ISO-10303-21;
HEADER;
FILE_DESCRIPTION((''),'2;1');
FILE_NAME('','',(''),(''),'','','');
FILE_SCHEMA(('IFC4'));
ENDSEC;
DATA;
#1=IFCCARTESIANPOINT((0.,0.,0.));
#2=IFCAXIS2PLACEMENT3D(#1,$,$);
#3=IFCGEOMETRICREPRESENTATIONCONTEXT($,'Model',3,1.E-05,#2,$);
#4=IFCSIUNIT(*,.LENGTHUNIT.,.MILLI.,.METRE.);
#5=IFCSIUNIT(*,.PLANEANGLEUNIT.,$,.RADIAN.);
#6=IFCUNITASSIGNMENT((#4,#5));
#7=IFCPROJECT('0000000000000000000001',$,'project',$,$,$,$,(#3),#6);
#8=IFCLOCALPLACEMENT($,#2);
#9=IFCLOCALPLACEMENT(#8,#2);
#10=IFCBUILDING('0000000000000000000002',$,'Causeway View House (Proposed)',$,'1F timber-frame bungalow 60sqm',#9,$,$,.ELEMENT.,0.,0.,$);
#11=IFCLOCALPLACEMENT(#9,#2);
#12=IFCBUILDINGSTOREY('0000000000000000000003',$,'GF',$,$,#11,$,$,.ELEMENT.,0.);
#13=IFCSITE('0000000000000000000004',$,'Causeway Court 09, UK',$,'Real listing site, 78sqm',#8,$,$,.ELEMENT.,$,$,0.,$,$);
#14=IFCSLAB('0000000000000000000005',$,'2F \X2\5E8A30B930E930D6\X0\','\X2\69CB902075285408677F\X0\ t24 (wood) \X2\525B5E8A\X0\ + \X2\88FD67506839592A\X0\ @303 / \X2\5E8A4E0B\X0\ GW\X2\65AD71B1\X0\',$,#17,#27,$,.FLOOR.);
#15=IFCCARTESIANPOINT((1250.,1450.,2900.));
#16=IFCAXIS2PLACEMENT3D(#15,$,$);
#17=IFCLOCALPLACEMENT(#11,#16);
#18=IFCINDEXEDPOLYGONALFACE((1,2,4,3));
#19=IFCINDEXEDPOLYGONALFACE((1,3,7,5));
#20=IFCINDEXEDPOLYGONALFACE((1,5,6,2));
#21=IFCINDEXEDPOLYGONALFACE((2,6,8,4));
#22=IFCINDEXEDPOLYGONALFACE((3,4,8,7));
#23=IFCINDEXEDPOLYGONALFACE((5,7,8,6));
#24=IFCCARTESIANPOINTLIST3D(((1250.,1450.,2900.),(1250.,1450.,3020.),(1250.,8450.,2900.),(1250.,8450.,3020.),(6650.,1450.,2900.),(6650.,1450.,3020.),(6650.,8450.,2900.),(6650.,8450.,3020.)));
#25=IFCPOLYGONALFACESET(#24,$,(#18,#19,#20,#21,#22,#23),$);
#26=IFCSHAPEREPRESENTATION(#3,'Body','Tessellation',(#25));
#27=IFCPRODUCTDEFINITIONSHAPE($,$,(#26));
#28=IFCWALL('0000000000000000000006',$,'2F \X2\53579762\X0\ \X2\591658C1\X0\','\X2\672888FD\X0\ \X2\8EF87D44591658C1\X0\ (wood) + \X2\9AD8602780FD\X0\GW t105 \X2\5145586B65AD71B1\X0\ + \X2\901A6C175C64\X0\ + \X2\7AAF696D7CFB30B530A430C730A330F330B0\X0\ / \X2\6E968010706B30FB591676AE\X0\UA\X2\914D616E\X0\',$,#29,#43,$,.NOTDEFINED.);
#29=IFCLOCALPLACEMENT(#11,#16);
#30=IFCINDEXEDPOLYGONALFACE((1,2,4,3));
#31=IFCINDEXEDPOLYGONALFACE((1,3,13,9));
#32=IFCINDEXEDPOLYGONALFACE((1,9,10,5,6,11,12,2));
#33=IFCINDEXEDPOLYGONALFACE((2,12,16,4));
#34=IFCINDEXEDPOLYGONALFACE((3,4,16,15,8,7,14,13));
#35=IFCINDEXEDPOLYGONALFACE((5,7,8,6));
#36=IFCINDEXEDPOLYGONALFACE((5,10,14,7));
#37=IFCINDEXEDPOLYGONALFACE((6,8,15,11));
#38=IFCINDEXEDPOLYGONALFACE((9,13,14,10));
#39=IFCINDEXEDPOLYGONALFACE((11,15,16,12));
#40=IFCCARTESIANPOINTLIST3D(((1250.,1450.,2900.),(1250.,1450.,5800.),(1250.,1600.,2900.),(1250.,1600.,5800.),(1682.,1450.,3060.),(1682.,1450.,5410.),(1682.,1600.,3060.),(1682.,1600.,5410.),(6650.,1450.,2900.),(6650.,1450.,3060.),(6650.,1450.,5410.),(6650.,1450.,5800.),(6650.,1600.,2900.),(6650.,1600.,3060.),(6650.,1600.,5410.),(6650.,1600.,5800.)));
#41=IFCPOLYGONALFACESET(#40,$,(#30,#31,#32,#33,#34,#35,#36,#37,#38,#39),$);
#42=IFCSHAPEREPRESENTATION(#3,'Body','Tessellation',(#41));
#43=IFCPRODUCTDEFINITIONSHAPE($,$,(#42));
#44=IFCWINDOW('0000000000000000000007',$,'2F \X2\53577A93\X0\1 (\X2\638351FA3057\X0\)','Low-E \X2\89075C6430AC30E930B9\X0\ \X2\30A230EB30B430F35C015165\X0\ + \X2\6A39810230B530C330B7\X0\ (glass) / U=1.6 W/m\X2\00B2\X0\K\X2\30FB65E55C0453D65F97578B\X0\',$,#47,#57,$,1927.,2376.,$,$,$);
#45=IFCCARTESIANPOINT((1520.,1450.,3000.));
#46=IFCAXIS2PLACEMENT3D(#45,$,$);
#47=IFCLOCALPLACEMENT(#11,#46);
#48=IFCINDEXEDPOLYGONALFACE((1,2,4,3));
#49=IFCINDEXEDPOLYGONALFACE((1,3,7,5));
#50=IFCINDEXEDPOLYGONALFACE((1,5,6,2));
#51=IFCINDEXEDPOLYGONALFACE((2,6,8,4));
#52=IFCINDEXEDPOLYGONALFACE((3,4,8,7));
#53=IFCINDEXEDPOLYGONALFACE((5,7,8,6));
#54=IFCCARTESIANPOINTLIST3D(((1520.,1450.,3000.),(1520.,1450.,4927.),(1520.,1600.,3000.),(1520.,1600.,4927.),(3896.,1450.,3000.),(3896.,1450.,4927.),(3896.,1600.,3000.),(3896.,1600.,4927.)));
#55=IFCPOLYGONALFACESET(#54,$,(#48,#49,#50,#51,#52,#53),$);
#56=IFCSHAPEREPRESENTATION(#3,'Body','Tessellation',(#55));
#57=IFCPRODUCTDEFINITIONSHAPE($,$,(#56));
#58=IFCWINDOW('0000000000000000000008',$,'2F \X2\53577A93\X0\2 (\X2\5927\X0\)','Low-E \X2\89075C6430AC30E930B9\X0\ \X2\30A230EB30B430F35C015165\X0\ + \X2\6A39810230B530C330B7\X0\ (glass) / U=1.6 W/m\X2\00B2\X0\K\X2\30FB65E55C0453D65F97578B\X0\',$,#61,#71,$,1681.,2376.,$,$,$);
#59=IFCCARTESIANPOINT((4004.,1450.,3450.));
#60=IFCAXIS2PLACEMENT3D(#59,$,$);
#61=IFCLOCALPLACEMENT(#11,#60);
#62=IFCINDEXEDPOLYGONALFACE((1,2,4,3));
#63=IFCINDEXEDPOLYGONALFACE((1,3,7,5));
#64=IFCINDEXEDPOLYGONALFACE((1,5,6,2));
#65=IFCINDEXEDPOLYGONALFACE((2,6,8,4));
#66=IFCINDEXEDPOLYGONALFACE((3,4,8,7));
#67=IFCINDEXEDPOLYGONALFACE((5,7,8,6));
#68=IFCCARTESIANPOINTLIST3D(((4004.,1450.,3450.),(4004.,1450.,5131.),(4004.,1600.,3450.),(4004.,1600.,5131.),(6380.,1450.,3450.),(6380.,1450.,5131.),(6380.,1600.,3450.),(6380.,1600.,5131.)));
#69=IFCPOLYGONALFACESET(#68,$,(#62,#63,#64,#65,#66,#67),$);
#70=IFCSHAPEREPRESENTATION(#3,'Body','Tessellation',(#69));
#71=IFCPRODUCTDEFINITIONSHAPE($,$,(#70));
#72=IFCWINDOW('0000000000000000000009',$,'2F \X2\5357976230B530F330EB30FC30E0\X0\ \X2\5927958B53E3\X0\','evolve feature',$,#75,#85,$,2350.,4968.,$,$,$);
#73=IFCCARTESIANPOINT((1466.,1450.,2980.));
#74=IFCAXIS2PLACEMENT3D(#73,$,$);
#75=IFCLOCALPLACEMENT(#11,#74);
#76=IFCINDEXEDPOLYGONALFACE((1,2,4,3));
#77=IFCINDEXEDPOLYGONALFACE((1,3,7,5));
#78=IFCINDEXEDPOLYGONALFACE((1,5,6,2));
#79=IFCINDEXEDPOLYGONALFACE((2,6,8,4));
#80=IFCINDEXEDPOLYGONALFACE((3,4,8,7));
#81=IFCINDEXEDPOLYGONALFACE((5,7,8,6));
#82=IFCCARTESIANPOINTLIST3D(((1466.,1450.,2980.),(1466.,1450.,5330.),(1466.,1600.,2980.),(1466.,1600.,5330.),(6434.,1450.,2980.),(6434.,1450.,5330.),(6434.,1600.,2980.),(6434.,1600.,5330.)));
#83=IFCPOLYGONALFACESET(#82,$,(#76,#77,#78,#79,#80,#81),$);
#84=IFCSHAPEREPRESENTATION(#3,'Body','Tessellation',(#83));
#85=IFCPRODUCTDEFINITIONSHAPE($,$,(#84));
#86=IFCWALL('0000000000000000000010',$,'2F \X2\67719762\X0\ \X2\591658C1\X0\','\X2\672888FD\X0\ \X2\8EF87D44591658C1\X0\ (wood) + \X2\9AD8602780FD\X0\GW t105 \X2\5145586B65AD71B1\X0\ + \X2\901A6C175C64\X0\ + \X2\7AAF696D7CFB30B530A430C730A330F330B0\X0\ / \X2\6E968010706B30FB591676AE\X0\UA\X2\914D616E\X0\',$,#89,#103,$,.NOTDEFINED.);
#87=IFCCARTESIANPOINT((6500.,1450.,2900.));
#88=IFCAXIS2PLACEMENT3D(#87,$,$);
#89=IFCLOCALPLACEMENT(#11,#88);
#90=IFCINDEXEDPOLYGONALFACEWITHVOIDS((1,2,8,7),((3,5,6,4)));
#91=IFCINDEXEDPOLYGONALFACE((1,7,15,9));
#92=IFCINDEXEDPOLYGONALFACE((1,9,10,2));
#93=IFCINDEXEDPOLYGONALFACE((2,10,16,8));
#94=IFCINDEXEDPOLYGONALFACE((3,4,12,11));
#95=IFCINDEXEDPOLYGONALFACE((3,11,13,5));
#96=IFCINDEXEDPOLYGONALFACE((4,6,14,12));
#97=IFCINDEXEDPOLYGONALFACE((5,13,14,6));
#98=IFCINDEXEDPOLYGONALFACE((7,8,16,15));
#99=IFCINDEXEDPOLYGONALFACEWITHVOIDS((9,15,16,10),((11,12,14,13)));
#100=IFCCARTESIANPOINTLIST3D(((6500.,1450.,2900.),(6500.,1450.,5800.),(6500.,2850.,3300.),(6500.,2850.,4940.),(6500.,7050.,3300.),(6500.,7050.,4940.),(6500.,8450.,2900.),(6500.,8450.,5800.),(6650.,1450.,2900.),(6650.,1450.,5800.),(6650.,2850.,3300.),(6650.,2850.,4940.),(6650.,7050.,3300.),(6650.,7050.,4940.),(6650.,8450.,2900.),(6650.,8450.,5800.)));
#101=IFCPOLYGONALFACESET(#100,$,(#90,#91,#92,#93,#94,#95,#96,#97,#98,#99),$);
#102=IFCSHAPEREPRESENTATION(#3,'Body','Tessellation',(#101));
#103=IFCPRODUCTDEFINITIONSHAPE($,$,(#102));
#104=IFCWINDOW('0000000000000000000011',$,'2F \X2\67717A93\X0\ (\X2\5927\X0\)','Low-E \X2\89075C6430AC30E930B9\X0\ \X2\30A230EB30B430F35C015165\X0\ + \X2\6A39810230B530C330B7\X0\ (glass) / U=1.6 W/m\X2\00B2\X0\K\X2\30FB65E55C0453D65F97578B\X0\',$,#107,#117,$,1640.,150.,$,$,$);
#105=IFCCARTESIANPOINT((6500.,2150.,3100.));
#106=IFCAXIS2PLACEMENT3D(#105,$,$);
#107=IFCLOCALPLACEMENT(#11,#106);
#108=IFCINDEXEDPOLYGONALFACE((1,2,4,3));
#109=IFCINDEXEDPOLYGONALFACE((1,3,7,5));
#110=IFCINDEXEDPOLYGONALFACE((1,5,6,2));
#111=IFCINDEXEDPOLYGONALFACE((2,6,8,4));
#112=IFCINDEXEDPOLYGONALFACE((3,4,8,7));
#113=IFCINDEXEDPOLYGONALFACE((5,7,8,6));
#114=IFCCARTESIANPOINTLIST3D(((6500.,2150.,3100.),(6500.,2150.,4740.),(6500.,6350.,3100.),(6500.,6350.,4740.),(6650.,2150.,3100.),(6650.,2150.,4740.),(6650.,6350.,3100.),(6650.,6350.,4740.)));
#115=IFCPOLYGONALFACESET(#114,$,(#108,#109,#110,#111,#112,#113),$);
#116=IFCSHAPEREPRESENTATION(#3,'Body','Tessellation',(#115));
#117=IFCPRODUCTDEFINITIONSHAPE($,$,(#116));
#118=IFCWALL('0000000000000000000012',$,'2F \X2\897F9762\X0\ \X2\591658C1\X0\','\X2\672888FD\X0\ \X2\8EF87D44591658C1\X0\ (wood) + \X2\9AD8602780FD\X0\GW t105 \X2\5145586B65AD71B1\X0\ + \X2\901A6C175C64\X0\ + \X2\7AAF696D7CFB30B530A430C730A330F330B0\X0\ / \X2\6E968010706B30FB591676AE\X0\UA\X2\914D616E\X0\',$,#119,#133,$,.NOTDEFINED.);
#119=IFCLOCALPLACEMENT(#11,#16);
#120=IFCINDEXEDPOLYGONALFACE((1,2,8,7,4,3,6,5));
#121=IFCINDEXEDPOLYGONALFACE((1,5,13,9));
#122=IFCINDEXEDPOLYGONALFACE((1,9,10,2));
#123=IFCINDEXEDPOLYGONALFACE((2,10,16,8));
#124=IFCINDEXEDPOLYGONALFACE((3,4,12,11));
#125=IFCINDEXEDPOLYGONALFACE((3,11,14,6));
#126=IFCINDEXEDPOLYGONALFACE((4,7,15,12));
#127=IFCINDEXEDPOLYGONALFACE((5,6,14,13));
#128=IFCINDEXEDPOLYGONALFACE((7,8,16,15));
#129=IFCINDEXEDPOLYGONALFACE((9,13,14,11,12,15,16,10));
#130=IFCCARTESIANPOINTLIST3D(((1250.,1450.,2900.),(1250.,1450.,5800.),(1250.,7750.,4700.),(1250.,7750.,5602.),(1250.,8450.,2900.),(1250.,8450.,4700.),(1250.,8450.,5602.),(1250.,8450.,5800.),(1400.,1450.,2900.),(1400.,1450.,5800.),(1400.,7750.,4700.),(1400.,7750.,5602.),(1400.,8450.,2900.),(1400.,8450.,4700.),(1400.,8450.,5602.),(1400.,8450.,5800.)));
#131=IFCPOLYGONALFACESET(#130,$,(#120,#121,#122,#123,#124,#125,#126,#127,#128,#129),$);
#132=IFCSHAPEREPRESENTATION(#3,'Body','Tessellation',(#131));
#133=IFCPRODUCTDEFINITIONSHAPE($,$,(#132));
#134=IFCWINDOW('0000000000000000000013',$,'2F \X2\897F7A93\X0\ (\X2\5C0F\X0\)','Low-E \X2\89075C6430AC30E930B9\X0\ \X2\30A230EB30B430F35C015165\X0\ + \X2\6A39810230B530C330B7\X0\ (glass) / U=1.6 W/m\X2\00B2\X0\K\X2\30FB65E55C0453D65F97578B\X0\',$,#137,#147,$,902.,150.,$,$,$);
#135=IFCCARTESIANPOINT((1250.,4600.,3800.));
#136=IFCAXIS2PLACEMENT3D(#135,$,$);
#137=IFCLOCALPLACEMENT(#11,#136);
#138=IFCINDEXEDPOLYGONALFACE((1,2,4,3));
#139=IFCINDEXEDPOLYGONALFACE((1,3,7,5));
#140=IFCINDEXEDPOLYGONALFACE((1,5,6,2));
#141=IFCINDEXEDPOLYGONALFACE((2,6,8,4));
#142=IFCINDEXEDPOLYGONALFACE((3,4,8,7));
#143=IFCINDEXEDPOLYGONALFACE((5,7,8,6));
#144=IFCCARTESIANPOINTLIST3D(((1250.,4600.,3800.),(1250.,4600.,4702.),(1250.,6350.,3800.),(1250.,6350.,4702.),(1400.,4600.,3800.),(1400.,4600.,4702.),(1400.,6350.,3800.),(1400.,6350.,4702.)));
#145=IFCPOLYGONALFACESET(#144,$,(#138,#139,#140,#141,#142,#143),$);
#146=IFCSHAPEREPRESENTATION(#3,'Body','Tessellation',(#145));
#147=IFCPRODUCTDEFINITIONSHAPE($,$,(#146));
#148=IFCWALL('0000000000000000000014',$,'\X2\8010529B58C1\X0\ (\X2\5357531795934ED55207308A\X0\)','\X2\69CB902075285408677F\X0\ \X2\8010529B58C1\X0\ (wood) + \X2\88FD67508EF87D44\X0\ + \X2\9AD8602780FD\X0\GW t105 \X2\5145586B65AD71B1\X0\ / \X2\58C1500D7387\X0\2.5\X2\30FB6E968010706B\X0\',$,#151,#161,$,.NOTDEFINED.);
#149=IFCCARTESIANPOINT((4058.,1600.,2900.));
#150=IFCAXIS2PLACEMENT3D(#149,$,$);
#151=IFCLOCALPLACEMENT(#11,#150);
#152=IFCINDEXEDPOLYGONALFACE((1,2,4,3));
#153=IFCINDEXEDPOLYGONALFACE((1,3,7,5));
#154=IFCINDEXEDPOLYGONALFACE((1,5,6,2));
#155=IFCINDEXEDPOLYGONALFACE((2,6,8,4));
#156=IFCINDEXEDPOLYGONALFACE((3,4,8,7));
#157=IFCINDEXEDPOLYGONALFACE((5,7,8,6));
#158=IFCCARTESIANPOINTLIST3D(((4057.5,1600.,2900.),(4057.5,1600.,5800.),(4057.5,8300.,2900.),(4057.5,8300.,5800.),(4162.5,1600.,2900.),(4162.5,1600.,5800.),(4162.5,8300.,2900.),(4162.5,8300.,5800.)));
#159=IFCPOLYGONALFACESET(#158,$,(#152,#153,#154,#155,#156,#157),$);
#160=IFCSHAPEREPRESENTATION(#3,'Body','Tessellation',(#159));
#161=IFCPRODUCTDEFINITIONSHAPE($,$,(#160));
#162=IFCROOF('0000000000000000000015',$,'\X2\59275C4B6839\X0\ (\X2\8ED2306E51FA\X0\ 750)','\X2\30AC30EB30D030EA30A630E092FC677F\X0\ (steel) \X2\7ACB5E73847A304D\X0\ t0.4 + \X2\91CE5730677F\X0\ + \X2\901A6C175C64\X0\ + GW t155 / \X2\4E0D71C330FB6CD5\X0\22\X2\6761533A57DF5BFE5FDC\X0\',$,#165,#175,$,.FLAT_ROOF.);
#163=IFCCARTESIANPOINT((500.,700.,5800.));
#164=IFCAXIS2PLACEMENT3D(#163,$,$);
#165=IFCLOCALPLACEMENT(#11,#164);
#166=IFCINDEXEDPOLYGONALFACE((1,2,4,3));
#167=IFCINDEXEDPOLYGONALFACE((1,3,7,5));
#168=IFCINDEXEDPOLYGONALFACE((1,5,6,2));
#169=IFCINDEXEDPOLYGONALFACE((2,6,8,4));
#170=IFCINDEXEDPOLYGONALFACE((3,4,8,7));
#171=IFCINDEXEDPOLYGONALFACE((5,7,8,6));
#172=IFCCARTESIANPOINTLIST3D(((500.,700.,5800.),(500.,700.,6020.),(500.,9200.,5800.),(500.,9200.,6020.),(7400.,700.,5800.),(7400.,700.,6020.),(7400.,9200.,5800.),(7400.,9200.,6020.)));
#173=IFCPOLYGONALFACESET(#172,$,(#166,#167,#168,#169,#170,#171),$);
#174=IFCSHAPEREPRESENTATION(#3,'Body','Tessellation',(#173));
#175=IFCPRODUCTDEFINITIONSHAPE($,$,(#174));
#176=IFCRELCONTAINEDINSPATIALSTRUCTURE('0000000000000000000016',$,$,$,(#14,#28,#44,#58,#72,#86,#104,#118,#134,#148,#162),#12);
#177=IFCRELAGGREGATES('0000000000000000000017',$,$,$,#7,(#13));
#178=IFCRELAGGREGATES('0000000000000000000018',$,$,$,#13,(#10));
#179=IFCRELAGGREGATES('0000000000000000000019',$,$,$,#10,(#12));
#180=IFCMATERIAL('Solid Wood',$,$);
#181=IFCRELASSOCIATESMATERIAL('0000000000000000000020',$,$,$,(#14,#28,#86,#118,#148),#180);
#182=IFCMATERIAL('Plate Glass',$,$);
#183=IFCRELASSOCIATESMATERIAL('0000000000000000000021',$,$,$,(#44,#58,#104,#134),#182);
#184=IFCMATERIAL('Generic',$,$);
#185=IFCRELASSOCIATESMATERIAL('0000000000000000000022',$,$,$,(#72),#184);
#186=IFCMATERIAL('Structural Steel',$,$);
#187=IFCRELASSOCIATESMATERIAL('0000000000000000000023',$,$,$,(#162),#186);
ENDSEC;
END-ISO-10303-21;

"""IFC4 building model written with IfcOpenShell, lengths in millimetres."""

from ifc_helpers import new_model, si_unit, frame, frame_2d, origin, place, context, project, spatial, rectangle, extrude, material, element, fill, save


model = new_model("IFC4")

# Units and contexts
model_context = context("Model", 3, precision=1e-05, world=origin())
ifc_project = project(units=[si_unit("LENGTHUNIT", "METRE", prefix="MILLI"), si_unit("PLANEANGLEUNIT", "RADIAN")], contexts=[model_context])

# Site, building, storey
site_placement = place(None, origin())
site = spatial("IfcSite", under=ifc_project, at=site_placement, Name="Causeway Court 09, UK", ObjectType="Real listing site, 78sqm", CompositionType="ELEMENT", RefElevation=0.0)
building_placement = place(site_placement, origin())
building = spatial("IfcBuilding", under=site, at=building_placement, Name="Causeway View House (Proposed)", ObjectType="1F timber-frame bungalow 60sqm", CompositionType="ELEMENT", ElevationOfRefHeight=0.0, ElevationOfTerrain=0.0)
storey_placement = place(building_placement, origin())
storey = spatial("IfcBuildingStorey", under=building, at=storey_placement, Name="GF", CompositionType="ELEMENT", Elevation=0.0)

# Slab
ifc_material_1 = material(Name="Solid Wood")
slab_placement = place(storey_placement, frame((1250.0, 1450.0, 2900.0)))
element("IfcSlab", 1, at=slab_placement, inside=storey, material=ifc_material_1, Name="2F 床スラブ", Description="構造用合板 t24 (wood) 剛床 + 製材根太 @303 / 床下 GW断熱", PredefinedType="FLOOR", context=model_context, shape_type="SweptSolid", body=[
    extrude(rectangle(XDim=5400.0, YDim=7000.0, at=frame_2d((2700.0, 3500.0))), frame((1250.0, 1450.0, 2900.0)), (0.0, 0.0, 1.0), 120.0),
])

# Wall, openings, windows
wall_1_placement = place(storey_placement, frame((1250.0, 1450.0, 2900.0)))
wall_1 = element("IfcWall", 2, at=wall_1_placement, inside=storey, material=ifc_material_1, Name="2F 南面 外壁", Description="木製 軸組外壁 (wood) + 高性能GW t105 充填断熱 + 通気層 + 窯業系サイディング / 準耐火・外皮UA配慮", PredefinedType="NOTDEFINED", context=model_context, shape_type="SweptSolid", body=[
    extrude(rectangle(XDim=5400.0, YDim=150.0, at=frame_2d((2700.0, 75.0))), frame((1250.0, 1450.0, 2900.0)), (0.0, 0.0, 1.0), 2900.0),
])
opening_1_placement = place(storey_placement, frame((1520.0, 1450.0, 3000.0)))
opening_1 = element("IfcOpeningElement", 3, at=opening_1_placement, cuts=wall_1, PredefinedType="NOTDEFINED", context=model_context, shape_type="SweptSolid", body=[
    extrude(rectangle(XDim=2376.0, YDim=150.0, at=frame_2d((1188.0, 75.0))), frame((1520.0, 1450.0, 3000.0)), (0.0, 0.0, 1.0), 1927.0),
])
opening_2_placement = place(storey_placement, frame((4004.0, 1450.0, 3450.0)))
opening_2 = element("IfcOpeningElement", 4, at=opening_2_placement, cuts=wall_1, PredefinedType="NOTDEFINED", context=model_context, shape_type="SweptSolid", body=[
    extrude(rectangle(XDim=2376.0, YDim=150.0, at=frame_2d((1188.0, 75.0))), frame((4004.0, 1450.0, 3450.0)), (0.0, 0.0, 1.0), 1681.0),
])
opening_3_placement = place(storey_placement, frame((1466.0, 1450.0, 2980.0)))
opening_3 = element("IfcOpeningElement", 5, at=opening_3_placement, cuts=wall_1, PredefinedType="NOTDEFINED", context=model_context, shape_type="SweptSolid", body=[
    extrude(rectangle(XDim=4968.0, YDim=150.0, at=frame_2d((2484.0, 75.0))), frame((1466.0, 1450.0, 2980.0)), (0.0, 0.0, 1.0), 2350.0),
])
ifc_material_2 = material(Name="Plate Glass")
window_1_placement = place(storey_placement, frame((1520.0, 1450.0, 3000.0)))
window_1 = element("IfcWindow", 6, at=window_1_placement, inside=storey, material=ifc_material_2, Name="2F 南窓1 (掃出し)", Description="Low-E 複層ガラス アルゴン封入 + 樹脂サッシ (glass) / U=1.6 W/m²K・日射取得型", OverallHeight=1927.0, OverallWidth=2376.0, context=model_context, shape_type="SweptSolid", body=[
    extrude(rectangle(XDim=2376.0, YDim=150.0, at=frame_2d((1188.0, 75.0))), frame((1520.0, 1450.0, 3000.0)), (0.0, 0.0, 1.0), 1927.0),
])
fill(opening_1, window_1)
window_2_placement = place(storey_placement, frame((4004.0, 1450.0, 3450.0)))
window_2 = element("IfcWindow", 7, at=window_2_placement, inside=storey, material=ifc_material_2, Name="2F 南窓2 (大)", Description="Low-E 複層ガラス アルゴン封入 + 樹脂サッシ (glass) / U=1.6 W/m²K・日射取得型", OverallHeight=1681.0, OverallWidth=2376.0, context=model_context, shape_type="SweptSolid", body=[
    extrude(rectangle(XDim=2376.0, YDim=150.0, at=frame_2d((1188.0, 75.0))), frame((4004.0, 1450.0, 3450.0)), (0.0, 0.0, 1.0), 1681.0),
])
fill(opening_2, window_2)
ifc_material_3 = material(Name="Generic")
window_3_placement = place(storey_placement, frame((1466.0, 1450.0, 2980.0)))
window_3 = element("IfcWindow", 8, at=window_3_placement, inside=storey, material=ifc_material_3, Name="2F 南面サンルーム 大開口", Description="evolve feature", OverallHeight=2350.0, OverallWidth=4968.0, context=model_context, shape_type="SweptSolid", body=[
    extrude(rectangle(XDim=4968.0, YDim=150.0, at=frame_2d((2484.0, 75.0))), frame((1466.0, 1450.0, 2980.0)), (0.0, 0.0, 1.0), 2350.0),
])
fill(opening_3, window_3)

# Walls, openings, windows
wall_2_placement = place(storey_placement, frame((6500.0, 1450.0, 2900.0)))
wall_2 = element("IfcWall", 9, at=wall_2_placement, inside=storey, material=ifc_material_1, Name="2F 東面 外壁", Description="木製 軸組外壁 (wood) + 高性能GW t105 充填断熱 + 通気層 + 窯業系サイディング / 準耐火・外皮UA配慮", PredefinedType="NOTDEFINED", context=model_context, shape_type="SweptSolid", body=[
    extrude(rectangle(XDim=150.0, YDim=7000.0, at=frame_2d((75.0, 3500.0))), frame((6500.0, 1450.0, 2900.0)), (0.0, 0.0, 1.0), 2900.0),
])
opening_4_placement = place(storey_placement, frame((6500.0, 2150.0, 3100.0)))
opening_4 = element("IfcOpeningElement", 10, at=opening_4_placement, cuts=wall_2, PredefinedType="NOTDEFINED", context=model_context, shape_type="SweptSolid", body=[
    extrude(rectangle(XDim=150.0, YDim=4200.0, at=frame_2d((75.0, 2100.0))), frame((6500.0, 2150.0, 3100.0)), (0.0, 0.0, 1.0), 1640.0),
])
window_4_placement = place(storey_placement, frame((6500.0, 2150.0, 3100.0)))
window_4 = element("IfcWindow", 11, at=window_4_placement, inside=storey, material=ifc_material_2, Name="2F 東窓 (大)", Description="Low-E 複層ガラス アルゴン封入 + 樹脂サッシ (glass) / U=1.6 W/m²K・日射取得型", OverallHeight=1640.0, OverallWidth=150.0, context=model_context, shape_type="SweptSolid", body=[
    extrude(rectangle(XDim=150.0, YDim=4200.0, at=frame_2d((75.0, 2100.0))), frame((6500.0, 2150.0, 3100.0)), (0.0, 0.0, 1.0), 1640.0),
])
fill(opening_4, window_4)
wall_3_placement = place(storey_placement, frame((1250.0, 1450.0, 2900.0)))
wall_3 = element("IfcWall", 12, at=wall_3_placement, inside=storey, material=ifc_material_1, Name="2F 西面 外壁", Description="木製 軸組外壁 (wood) + 高性能GW t105 充填断熱 + 通気層 + 窯業系サイディング / 準耐火・外皮UA配慮", PredefinedType="NOTDEFINED", context=model_context, shape_type="SweptSolid", body=[
    extrude(rectangle(XDim=150.0, YDim=7000.0, at=frame_2d((75.0, 3500.0))), frame((1250.0, 1450.0, 2900.0)), (0.0, 0.0, 1.0), 2900.0),
])
opening_5_placement = place(storey_placement, frame((1250.0, 4600.0, 3800.0)))
opening_5 = element("IfcOpeningElement", 13, at=opening_5_placement, cuts=wall_3, PredefinedType="NOTDEFINED", context=model_context, shape_type="SweptSolid", body=[
    extrude(rectangle(XDim=150.0, YDim=1750.0, at=frame_2d((75.0, 875.0))), frame((1250.0, 4600.0, 3800.0)), (0.0, 0.0, 1.0), 902.0),
])
window_5_placement = place(storey_placement, frame((1250.0, 4600.0, 3800.0)))
window_5 = element("IfcWindow", 14, at=window_5_placement, inside=storey, material=ifc_material_2, Name="2F 西窓 (小)", Description="Low-E 複層ガラス アルゴン封入 + 樹脂サッシ (glass) / U=1.6 W/m²K・日射取得型", OverallHeight=902.0, OverallWidth=150.0, context=model_context, shape_type="SweptSolid", body=[
    extrude(rectangle(XDim=150.0, YDim=1750.0, at=frame_2d((75.0, 875.0))), frame((1250.0, 4600.0, 3800.0)), (0.0, 0.0, 1.0), 902.0),
])
fill(opening_5, window_5)

# Wall
wall_4_placement = place(storey_placement, frame((4058.0, 1600.0, 2900.0)))
element("IfcWall", 15, at=wall_4_placement, inside=storey, material=ifc_material_1, Name="耐力壁 (南北間仕切り)", Description="構造用合板 耐力壁 (wood) + 製材軸組 + 高性能GW t105 充填断熱 / 壁倍率2.5・準耐火", PredefinedType="NOTDEFINED", context=model_context, shape_type="SweptSolid", body=[
    extrude(rectangle(XDim=105.0, YDim=6700.0, at=frame_2d((52.0, 3350.0))), frame((4058.0, 1600.0, 2900.0)), (0.0, 0.0, 1.0), 2900.0),
])

# Roof
ifc_material_4 = material(Name="Structural Steel")
roof_placement = place(storey_placement, frame((500.0, 700.0, 5800.0)))
element("IfcRoof", 16, at=roof_placement, inside=storey, material=ifc_material_4, Name="大屋根 (軒の出 750)", Description="ガルバリウム鋼板 (steel) 立平葺き t0.4 + 野地板 + 通気層 + GW t155 / 不燃・法22条区域対応", PredefinedType="FLAT_ROOF", context=model_context, shape_type="SweptSolid", body=[
    extrude(rectangle(XDim=6900.0, YDim=8500.0, at=frame_2d((3450.0, 4250.0))), frame((500.0, 700.0, 5800.0)), (0.0, 0.0, 1.0), 220.0),
])

save(model, "model.ifc")
